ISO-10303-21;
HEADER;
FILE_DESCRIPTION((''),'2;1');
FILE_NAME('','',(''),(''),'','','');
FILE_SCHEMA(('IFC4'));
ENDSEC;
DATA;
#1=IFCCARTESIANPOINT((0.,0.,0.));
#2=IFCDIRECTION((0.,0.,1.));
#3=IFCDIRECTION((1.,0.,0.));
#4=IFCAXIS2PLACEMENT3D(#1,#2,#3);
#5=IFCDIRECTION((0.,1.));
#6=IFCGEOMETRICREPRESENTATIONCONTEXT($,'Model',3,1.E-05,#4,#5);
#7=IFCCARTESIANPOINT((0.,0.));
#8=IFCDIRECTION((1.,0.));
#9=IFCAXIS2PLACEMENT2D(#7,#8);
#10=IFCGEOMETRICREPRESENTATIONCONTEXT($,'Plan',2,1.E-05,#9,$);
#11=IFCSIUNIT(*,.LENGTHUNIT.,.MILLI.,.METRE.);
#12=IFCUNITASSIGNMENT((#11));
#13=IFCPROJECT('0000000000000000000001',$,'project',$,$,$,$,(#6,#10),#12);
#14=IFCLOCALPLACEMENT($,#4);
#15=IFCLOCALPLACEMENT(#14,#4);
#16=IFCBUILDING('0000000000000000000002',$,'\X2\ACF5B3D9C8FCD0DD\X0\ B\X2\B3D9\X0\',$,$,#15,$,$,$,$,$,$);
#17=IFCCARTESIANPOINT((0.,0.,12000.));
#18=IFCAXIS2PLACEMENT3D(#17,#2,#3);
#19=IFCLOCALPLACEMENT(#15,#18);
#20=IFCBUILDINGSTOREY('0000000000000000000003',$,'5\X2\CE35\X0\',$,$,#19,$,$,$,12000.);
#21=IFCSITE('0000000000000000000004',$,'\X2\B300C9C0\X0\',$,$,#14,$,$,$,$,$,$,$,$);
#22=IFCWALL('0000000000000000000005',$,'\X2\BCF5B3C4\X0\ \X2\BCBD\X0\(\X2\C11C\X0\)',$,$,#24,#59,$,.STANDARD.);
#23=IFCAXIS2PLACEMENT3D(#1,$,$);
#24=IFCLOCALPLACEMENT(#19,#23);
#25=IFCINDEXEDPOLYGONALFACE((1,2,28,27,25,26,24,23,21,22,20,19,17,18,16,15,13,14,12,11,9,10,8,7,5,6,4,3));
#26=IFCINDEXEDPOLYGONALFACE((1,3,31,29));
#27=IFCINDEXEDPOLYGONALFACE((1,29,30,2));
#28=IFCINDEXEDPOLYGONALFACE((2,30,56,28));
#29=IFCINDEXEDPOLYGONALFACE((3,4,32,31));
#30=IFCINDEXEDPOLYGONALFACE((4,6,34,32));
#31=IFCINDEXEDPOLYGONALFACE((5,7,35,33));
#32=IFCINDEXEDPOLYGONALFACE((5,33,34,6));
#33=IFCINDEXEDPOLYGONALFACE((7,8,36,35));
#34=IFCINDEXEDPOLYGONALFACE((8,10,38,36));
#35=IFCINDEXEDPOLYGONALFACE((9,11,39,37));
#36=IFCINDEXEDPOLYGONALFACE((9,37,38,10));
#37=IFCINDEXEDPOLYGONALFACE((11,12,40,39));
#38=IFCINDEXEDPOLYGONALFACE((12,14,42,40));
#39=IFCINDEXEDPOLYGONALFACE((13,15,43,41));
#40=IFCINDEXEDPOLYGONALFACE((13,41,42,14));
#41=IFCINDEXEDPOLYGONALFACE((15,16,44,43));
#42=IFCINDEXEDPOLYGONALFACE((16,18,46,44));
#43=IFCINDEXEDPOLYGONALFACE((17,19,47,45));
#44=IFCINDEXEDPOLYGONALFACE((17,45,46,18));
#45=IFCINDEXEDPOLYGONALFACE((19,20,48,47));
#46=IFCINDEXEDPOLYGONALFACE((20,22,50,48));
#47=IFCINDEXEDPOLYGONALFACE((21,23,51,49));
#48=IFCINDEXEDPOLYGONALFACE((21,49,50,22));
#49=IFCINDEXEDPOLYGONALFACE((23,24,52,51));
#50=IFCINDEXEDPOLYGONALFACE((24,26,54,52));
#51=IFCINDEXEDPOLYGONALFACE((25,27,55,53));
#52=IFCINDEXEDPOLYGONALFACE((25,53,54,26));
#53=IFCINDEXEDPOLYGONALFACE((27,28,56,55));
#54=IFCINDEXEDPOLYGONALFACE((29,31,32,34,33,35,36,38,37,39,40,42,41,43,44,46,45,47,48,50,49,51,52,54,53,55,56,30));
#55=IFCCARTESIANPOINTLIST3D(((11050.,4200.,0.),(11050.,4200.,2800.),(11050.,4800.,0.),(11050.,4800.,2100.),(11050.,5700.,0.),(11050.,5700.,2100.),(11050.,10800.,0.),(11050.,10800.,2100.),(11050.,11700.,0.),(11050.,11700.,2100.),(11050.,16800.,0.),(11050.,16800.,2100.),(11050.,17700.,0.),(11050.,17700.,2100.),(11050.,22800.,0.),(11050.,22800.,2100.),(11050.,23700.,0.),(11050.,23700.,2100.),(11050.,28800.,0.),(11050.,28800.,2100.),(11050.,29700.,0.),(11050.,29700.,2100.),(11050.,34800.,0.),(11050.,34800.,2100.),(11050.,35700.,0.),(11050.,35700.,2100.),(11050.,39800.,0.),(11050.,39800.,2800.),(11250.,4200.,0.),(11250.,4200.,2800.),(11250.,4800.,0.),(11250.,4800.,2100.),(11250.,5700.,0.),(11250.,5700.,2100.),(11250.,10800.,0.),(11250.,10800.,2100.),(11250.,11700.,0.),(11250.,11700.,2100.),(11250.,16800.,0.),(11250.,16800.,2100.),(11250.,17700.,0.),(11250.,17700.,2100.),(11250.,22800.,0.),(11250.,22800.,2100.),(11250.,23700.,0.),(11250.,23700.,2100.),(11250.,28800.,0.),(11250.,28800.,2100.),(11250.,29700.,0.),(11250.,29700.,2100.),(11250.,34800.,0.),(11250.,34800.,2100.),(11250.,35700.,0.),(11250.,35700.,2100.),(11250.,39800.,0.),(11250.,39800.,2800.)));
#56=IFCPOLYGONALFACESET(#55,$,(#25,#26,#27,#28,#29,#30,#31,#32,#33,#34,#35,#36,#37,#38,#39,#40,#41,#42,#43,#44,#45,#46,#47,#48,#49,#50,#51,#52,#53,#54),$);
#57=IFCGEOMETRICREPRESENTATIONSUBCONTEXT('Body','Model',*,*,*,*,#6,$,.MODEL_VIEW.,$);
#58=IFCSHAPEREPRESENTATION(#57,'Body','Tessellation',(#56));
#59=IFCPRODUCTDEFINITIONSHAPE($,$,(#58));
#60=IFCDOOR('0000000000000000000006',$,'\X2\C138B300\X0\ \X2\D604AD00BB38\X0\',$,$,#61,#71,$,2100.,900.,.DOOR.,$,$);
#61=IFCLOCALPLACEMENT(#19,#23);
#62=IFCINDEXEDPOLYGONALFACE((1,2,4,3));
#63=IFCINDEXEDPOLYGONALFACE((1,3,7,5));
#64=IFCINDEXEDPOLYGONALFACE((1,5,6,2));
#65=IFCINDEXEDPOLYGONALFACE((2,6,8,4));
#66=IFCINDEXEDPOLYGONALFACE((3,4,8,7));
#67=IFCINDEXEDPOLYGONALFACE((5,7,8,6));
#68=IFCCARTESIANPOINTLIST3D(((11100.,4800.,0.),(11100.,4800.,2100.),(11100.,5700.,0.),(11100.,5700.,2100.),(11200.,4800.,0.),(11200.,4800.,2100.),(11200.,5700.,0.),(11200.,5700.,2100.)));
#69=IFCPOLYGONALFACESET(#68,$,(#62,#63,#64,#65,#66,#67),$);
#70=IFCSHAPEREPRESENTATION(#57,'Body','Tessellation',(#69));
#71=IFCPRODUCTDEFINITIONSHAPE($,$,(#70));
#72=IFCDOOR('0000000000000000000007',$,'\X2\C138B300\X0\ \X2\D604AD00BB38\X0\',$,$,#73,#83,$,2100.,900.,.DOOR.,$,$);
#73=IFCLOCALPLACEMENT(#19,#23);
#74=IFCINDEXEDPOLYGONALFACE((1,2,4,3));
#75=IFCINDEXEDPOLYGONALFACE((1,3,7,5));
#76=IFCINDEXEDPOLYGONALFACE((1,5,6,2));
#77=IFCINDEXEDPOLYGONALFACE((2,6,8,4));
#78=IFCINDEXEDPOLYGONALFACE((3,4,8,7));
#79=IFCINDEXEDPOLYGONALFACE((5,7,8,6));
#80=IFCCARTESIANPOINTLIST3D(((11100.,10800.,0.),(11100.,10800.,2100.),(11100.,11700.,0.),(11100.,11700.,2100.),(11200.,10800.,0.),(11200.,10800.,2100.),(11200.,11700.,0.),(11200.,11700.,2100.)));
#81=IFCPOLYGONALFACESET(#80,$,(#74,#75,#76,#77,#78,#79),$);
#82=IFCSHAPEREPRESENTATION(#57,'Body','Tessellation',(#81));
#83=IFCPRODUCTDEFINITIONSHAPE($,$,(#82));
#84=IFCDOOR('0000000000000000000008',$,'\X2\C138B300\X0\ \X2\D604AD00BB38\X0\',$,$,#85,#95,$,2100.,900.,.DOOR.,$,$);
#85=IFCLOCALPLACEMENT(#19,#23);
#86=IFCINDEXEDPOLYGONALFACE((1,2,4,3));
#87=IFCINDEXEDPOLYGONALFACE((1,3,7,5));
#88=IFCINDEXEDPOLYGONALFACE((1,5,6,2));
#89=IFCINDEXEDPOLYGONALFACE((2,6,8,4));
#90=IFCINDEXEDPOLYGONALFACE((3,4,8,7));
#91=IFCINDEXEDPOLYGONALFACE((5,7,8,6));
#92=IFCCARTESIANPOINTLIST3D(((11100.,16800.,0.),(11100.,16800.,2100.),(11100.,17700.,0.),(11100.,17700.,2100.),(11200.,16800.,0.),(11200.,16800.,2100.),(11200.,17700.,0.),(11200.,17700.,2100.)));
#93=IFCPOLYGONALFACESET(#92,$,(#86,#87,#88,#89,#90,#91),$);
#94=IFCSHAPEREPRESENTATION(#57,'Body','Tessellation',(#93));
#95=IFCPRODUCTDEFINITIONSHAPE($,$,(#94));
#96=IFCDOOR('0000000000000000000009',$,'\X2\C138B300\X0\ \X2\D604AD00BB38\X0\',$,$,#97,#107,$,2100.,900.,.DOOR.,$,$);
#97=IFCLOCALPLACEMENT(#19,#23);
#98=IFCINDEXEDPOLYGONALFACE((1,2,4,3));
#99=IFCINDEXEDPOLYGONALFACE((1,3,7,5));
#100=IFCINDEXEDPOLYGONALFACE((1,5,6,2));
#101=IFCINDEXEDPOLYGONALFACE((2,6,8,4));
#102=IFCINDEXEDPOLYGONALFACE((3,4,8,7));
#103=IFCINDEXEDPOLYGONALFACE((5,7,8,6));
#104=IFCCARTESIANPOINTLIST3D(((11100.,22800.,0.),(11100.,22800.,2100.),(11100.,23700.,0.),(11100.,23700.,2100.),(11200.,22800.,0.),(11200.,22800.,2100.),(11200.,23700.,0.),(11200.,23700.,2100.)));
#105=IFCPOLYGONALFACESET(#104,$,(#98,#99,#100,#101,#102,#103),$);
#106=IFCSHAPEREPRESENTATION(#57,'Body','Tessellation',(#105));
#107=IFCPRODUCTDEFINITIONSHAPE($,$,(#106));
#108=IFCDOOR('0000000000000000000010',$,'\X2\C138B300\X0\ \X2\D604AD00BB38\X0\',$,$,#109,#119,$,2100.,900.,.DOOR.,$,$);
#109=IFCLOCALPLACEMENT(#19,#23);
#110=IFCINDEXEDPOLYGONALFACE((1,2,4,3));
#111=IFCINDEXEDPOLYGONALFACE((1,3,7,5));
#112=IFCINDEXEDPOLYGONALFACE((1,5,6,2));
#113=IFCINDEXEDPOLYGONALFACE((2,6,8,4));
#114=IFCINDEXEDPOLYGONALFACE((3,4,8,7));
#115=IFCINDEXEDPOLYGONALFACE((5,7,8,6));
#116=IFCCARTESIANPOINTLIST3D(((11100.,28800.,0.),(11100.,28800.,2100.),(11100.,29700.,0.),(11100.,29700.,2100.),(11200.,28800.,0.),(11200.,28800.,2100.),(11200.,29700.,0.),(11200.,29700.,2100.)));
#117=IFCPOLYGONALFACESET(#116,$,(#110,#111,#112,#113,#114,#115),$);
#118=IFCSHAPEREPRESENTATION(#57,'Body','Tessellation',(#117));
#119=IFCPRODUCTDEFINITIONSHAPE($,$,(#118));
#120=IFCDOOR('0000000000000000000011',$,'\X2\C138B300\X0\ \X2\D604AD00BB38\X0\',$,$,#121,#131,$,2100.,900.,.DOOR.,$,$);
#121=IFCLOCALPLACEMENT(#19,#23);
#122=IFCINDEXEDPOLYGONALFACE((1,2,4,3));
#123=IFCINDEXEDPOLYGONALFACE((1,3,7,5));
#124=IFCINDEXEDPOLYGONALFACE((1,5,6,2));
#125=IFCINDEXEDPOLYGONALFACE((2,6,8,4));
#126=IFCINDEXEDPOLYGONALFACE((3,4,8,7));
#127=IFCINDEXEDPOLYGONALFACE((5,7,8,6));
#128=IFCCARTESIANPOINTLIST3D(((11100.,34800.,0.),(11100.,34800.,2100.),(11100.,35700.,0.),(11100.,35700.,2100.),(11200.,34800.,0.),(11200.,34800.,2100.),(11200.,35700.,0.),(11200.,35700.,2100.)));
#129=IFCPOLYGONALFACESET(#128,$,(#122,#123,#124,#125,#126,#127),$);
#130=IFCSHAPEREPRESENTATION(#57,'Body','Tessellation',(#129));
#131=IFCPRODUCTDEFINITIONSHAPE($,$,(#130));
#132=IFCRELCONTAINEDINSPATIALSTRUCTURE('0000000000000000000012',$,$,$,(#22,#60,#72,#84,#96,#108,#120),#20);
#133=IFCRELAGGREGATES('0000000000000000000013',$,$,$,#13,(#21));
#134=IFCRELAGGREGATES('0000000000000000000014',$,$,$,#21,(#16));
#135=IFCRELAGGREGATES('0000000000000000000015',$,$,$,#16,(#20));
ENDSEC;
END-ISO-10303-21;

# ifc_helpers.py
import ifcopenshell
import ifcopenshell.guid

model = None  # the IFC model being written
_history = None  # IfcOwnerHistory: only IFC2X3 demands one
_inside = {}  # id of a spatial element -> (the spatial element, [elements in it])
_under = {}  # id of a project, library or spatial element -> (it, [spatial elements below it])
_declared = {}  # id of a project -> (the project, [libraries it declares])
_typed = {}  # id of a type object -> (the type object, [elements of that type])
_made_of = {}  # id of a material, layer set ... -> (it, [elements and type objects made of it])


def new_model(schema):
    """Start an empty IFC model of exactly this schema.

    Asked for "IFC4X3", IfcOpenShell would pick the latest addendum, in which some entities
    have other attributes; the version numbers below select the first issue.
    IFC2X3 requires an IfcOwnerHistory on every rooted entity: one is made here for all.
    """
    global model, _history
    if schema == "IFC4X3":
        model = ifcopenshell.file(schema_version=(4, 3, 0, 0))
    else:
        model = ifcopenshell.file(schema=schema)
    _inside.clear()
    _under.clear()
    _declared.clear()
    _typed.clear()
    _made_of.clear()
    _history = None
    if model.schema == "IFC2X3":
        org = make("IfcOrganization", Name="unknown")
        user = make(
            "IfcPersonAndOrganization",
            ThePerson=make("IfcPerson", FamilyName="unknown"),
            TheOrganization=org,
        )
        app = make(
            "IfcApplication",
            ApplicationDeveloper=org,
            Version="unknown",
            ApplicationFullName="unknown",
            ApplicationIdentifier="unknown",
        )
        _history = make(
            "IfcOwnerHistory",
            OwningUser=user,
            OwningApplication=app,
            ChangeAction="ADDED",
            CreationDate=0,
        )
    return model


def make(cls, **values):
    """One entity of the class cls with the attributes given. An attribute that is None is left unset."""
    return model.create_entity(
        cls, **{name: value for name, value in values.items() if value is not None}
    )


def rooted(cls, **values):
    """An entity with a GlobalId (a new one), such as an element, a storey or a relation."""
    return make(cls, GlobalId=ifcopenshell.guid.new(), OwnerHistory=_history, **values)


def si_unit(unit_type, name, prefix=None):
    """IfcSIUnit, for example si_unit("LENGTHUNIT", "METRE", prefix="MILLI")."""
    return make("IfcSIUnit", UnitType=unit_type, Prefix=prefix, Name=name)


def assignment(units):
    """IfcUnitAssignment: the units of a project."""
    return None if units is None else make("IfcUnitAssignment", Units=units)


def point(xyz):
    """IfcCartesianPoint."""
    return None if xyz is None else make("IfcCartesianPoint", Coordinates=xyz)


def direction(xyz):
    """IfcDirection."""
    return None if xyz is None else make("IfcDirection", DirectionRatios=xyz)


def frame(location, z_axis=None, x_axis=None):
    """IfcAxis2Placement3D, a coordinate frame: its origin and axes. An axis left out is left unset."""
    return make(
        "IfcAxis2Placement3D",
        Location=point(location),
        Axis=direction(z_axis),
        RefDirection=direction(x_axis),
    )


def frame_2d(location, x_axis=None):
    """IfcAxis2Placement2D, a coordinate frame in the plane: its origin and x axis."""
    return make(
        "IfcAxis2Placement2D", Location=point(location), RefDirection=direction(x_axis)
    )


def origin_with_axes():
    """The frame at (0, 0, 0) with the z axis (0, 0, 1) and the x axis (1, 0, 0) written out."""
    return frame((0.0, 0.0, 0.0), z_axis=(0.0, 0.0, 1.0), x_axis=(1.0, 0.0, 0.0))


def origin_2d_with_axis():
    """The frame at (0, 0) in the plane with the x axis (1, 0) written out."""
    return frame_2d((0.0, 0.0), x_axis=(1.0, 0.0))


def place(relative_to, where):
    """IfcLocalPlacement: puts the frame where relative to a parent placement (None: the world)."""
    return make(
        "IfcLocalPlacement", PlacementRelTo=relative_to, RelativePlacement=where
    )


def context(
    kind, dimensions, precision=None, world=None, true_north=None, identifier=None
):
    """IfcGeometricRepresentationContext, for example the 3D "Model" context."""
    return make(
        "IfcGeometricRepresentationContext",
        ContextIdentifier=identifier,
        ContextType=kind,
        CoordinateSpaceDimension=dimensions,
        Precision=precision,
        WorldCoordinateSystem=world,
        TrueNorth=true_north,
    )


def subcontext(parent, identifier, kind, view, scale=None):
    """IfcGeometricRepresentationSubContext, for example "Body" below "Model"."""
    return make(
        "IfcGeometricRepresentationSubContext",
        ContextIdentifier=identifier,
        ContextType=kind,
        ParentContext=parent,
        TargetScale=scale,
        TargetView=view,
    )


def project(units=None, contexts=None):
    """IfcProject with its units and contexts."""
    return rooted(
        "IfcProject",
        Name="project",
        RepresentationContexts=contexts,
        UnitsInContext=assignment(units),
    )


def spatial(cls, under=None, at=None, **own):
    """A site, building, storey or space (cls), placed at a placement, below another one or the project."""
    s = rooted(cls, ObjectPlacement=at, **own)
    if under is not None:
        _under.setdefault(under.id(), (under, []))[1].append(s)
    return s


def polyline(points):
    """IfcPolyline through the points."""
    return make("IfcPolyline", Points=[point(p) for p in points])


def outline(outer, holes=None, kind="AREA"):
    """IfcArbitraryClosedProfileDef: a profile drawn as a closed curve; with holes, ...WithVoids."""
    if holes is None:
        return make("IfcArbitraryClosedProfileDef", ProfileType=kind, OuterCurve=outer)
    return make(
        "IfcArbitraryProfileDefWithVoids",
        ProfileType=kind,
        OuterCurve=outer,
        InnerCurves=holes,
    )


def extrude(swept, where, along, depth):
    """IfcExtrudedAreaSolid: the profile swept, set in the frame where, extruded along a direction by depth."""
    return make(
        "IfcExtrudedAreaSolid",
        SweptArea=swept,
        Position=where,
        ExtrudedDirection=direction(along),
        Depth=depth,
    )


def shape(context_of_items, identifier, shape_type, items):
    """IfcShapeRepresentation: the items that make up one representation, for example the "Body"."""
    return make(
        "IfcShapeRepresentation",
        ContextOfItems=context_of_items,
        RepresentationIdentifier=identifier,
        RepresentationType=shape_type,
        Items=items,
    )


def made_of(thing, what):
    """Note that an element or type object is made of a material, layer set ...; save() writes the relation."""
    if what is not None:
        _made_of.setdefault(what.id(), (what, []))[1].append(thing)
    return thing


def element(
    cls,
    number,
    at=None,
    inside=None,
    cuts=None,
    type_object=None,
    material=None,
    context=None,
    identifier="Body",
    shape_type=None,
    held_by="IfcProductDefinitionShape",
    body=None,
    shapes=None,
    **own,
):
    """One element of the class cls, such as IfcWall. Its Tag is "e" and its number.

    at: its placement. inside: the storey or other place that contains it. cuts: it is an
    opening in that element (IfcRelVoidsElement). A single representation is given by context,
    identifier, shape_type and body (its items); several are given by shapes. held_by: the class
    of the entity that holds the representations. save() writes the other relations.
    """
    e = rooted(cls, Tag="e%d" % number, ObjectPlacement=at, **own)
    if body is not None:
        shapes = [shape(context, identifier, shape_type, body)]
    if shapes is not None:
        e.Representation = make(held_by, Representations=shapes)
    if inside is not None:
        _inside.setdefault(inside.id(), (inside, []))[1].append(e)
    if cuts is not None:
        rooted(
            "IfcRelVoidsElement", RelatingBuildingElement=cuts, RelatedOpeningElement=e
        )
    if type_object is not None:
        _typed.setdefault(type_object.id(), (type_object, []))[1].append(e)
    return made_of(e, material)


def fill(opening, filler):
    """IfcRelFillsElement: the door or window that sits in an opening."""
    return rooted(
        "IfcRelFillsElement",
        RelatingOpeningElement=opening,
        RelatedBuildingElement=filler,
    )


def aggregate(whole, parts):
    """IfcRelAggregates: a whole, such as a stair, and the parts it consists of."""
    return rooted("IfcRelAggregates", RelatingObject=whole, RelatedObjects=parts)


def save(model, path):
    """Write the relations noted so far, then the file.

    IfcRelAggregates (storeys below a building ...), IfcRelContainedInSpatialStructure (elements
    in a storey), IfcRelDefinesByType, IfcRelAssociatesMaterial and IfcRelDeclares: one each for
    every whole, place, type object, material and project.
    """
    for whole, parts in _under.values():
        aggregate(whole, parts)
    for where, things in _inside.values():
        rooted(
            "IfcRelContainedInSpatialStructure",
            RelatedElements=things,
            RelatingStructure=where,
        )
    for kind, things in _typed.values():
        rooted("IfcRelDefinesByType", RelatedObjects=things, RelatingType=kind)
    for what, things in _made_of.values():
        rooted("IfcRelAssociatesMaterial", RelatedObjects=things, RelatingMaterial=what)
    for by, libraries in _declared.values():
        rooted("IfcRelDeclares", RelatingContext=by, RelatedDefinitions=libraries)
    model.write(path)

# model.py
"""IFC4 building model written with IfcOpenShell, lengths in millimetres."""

from ifc_helpers import new_model, si_unit, direction, frame, origin_with_axes, origin_2d_with_axis, place, context, subcontext, project, spatial, polyline, outline, extrude, element, fill, save


model = new_model("IFC4")

# Units and contexts
model_context = context("Model", 3, precision=1e-05, world=origin_with_axes(), true_north=direction((0.0, 1.0)))
plan_context = context("Plan", 2, precision=1e-05, world=origin_2d_with_axis())
body_context = subcontext(model_context, "Body", "Model", "MODEL_VIEW")
ifc_project = project(units=[si_unit("LENGTHUNIT", "METRE", prefix="MILLI")], contexts=[model_context, plan_context])

# Site, building, storey
site_placement = place(None, origin_with_axes())
site = spatial("IfcSite", under=ifc_project, at=site_placement, Name="대지")
building_placement = place(site_placement, origin_with_axes())
building = spatial("IfcBuilding", under=site, at=building_placement, Name="공동주택 B동")
storey_placement = place(building_placement, frame((0.0, 0.0, 12000.0), z_axis=(0.0, 0.0, 1.0), x_axis=(1.0, 0.0, 0.0)))
storey = spatial("IfcBuildingStorey", under=building, at=storey_placement, Name="5층", Elevation=12000.0)

# Wall, openings, doors
wall_1_placement = place(storey_placement, origin_with_axes())
wall_1 = element("IfcWall", 1, at=wall_1_placement, inside=storey, Name="복도 벽(서)", PredefinedType="STANDARD", context=body_context, shape_type="SweptSolid", body=[
    extrude(outline(polyline([(11050.0, 4200.0), (11050.0, 39800.0), (11250.0, 39800.0), (11250.0, 4200.0), (11050.0, 4200.0)])), origin_with_axes(), (0.0, 0.0, 1.0), 2800.0),
])
opening_1_placement = place(storey_placement, origin_with_axes())
opening_1 = element("IfcOpeningElement", 2, at=opening_1_placement, cuts=wall_1, PredefinedType="OPENING", context=body_context, shape_type="SweptSolid", body=[
    extrude(outline(polyline([(11300.0, 4800.0), (11300.0, 5700.0), (11000.0, 5700.0), (11000.0, 4800.0), (11300.0, 4800.0)])), origin_with_axes(), (0.0, 0.0, 1.0), 2100.0),
])
opening_2_placement = place(storey_placement, origin_with_axes())
opening_2 = element("IfcOpeningElement", 3, at=opening_2_placement, cuts=wall_1, PredefinedType="OPENING", context=body_context, shape_type="SweptSolid", body=[
    extrude(outline(polyline([(11300.0, 10800.0), (11300.0, 11700.0), (11000.0, 11700.0), (11000.0, 10800.0), (11300.0, 10800.0)])), origin_with_axes(), (0.0, 0.0, 1.0), 2100.0),
])
opening_3_placement = place(storey_placement, origin_with_axes())
opening_3 = element("IfcOpeningElement", 4, at=opening_3_placement, cuts=wall_1, PredefinedType="OPENING", context=body_context, shape_type="SweptSolid", body=[
    extrude(outline(polyline([(11300.0, 16800.0), (11300.0, 17700.0), (11000.0, 17700.0), (11000.0, 16800.0), (11300.0, 16800.0)])), origin_with_axes(), (0.0, 0.0, 1.0), 2100.0),
])
opening_4_placement = place(storey_placement, origin_with_axes())
opening_4 = element("IfcOpeningElement", 5, at=opening_4_placement, cuts=wall_1, PredefinedType="OPENING", context=body_context, shape_type="SweptSolid", body=[
    extrude(outline(polyline([(11300.0, 22800.0), (11300.0, 23700.0), (11000.0, 23700.0), (11000.0, 22800.0), (11300.0, 22800.0)])), origin_with_axes(), (0.0, 0.0, 1.0), 2100.0),
])
opening_5_placement = place(storey_placement, origin_with_axes())
opening_5 = element("IfcOpeningElement", 6, at=opening_5_placement, cuts=wall_1, PredefinedType="OPENING", context=body_context, shape_type="SweptSolid", body=[
    extrude(outline(polyline([(11300.0, 28800.0), (11300.0, 29700.0), (11000.0, 29700.0), (11000.0, 28800.0), (11300.0, 28800.0)])), origin_with_axes(), (0.0, 0.0, 1.0), 2100.0),
])
opening_6_placement = place(storey_placement, origin_with_axes())
opening_6 = element("IfcOpeningElement", 7, at=opening_6_placement, cuts=wall_1, PredefinedType="OPENING", context=body_context, shape_type="SweptSolid", body=[
    extrude(outline(polyline([(11300.0, 34800.0), (11300.0, 35700.0), (11000.0, 35700.0), (11000.0, 34800.0), (11300.0, 34800.0)])), origin_with_axes(), (0.0, 0.0, 1.0), 2100.0),
])
door_1_placement = place(storey_placement, origin_with_axes())
door_1 = element("IfcDoor", 8, at=door_1_placement, inside=storey, Name="세대 현관문", OverallHeight=2100.0, OverallWidth=900.0, PredefinedType="DOOR", context=body_context, shape_type="SweptSolid", body=[
    extrude(outline(polyline([(11200.0, 4800.0), (11200.0, 5700.0), (11100.0, 5700.0), (11100.0, 4800.0), (11200.0, 4800.0)])), origin_with_axes(), (0.0, 0.0, 1.0), 2100.0),
])
fill(opening_1, door_1)
door_2_placement = place(storey_placement, origin_with_axes())
door_2 = element("IfcDoor", 9, at=door_2_placement, inside=storey, Name="세대 현관문", OverallHeight=2100.0, OverallWidth=900.0, PredefinedType="DOOR", context=body_context, shape_type="SweptSolid", body=[
    extrude(outline(polyline([(11200.0, 10800.0), (11200.0, 11700.0), (11100.0, 11700.0), (11100.0, 10800.0), (11200.0, 10800.0)])), origin_with_axes(), (0.0, 0.0, 1.0), 2100.0),
])
fill(opening_2, door_2)
door_3_placement = place(storey_placement, origin_with_axes())
door_3 = element("IfcDoor", 10, at=door_3_placement, inside=storey, Name="세대 현관문", OverallHeight=2100.0, OverallWidth=900.0, PredefinedType="DOOR", context=body_context, shape_type="SweptSolid", body=[
    extrude(outline(polyline([(11200.0, 16800.0), (11200.0, 17700.0), (11100.0, 17700.0), (11100.0, 16800.0), (11200.0, 16800.0)])), origin_with_axes(), (0.0, 0.0, 1.0), 2100.0),
])
fill(opening_3, door_3)
door_4_placement = place(storey_placement, origin_with_axes())
door_4 = element("IfcDoor", 11, at=door_4_placement, inside=storey, Name="세대 현관문", OverallHeight=2100.0, OverallWidth=900.0, PredefinedType="DOOR", context=body_context, shape_type="SweptSolid", body=[
    extrude(outline(polyline([(11200.0, 22800.0), (11200.0, 23700.0), (11100.0, 23700.0), (11100.0, 22800.0), (11200.0, 22800.0)])), origin_with_axes(), (0.0, 0.0, 1.0), 2100.0),
])
fill(opening_4, door_4)
door_5_placement = place(storey_placement, origin_with_axes())
door_5 = element("IfcDoor", 12, at=door_5_placement, inside=storey, Name="세대 현관문", OverallHeight=2100.0, OverallWidth=900.0, PredefinedType="DOOR", context=body_context, shape_type="SweptSolid", body=[
    extrude(outline(polyline([(11200.0, 28800.0), (11200.0, 29700.0), (11100.0, 29700.0), (11100.0, 28800.0), (11200.0, 28800.0)])), origin_with_axes(), (0.0, 0.0, 1.0), 2100.0),
])
fill(opening_5, door_5)
door_6_placement = place(storey_placement, origin_with_axes())
door_6 = element("IfcDoor", 13, at=door_6_placement, inside=storey, Name="세대 현관문", OverallHeight=2100.0, OverallWidth=900.0, PredefinedType="DOOR", context=body_context, shape_type="SweptSolid", body=[
    extrude(outline(polyline([(11200.0, 34800.0), (11200.0, 35700.0), (11100.0, 35700.0), (11100.0, 34800.0), (11200.0, 34800.0)])), origin_with_axes(), (0.0, 0.0, 1.0), 2100.0),
])
fill(opening_6, door_6)

save(model, "model.ifc")
